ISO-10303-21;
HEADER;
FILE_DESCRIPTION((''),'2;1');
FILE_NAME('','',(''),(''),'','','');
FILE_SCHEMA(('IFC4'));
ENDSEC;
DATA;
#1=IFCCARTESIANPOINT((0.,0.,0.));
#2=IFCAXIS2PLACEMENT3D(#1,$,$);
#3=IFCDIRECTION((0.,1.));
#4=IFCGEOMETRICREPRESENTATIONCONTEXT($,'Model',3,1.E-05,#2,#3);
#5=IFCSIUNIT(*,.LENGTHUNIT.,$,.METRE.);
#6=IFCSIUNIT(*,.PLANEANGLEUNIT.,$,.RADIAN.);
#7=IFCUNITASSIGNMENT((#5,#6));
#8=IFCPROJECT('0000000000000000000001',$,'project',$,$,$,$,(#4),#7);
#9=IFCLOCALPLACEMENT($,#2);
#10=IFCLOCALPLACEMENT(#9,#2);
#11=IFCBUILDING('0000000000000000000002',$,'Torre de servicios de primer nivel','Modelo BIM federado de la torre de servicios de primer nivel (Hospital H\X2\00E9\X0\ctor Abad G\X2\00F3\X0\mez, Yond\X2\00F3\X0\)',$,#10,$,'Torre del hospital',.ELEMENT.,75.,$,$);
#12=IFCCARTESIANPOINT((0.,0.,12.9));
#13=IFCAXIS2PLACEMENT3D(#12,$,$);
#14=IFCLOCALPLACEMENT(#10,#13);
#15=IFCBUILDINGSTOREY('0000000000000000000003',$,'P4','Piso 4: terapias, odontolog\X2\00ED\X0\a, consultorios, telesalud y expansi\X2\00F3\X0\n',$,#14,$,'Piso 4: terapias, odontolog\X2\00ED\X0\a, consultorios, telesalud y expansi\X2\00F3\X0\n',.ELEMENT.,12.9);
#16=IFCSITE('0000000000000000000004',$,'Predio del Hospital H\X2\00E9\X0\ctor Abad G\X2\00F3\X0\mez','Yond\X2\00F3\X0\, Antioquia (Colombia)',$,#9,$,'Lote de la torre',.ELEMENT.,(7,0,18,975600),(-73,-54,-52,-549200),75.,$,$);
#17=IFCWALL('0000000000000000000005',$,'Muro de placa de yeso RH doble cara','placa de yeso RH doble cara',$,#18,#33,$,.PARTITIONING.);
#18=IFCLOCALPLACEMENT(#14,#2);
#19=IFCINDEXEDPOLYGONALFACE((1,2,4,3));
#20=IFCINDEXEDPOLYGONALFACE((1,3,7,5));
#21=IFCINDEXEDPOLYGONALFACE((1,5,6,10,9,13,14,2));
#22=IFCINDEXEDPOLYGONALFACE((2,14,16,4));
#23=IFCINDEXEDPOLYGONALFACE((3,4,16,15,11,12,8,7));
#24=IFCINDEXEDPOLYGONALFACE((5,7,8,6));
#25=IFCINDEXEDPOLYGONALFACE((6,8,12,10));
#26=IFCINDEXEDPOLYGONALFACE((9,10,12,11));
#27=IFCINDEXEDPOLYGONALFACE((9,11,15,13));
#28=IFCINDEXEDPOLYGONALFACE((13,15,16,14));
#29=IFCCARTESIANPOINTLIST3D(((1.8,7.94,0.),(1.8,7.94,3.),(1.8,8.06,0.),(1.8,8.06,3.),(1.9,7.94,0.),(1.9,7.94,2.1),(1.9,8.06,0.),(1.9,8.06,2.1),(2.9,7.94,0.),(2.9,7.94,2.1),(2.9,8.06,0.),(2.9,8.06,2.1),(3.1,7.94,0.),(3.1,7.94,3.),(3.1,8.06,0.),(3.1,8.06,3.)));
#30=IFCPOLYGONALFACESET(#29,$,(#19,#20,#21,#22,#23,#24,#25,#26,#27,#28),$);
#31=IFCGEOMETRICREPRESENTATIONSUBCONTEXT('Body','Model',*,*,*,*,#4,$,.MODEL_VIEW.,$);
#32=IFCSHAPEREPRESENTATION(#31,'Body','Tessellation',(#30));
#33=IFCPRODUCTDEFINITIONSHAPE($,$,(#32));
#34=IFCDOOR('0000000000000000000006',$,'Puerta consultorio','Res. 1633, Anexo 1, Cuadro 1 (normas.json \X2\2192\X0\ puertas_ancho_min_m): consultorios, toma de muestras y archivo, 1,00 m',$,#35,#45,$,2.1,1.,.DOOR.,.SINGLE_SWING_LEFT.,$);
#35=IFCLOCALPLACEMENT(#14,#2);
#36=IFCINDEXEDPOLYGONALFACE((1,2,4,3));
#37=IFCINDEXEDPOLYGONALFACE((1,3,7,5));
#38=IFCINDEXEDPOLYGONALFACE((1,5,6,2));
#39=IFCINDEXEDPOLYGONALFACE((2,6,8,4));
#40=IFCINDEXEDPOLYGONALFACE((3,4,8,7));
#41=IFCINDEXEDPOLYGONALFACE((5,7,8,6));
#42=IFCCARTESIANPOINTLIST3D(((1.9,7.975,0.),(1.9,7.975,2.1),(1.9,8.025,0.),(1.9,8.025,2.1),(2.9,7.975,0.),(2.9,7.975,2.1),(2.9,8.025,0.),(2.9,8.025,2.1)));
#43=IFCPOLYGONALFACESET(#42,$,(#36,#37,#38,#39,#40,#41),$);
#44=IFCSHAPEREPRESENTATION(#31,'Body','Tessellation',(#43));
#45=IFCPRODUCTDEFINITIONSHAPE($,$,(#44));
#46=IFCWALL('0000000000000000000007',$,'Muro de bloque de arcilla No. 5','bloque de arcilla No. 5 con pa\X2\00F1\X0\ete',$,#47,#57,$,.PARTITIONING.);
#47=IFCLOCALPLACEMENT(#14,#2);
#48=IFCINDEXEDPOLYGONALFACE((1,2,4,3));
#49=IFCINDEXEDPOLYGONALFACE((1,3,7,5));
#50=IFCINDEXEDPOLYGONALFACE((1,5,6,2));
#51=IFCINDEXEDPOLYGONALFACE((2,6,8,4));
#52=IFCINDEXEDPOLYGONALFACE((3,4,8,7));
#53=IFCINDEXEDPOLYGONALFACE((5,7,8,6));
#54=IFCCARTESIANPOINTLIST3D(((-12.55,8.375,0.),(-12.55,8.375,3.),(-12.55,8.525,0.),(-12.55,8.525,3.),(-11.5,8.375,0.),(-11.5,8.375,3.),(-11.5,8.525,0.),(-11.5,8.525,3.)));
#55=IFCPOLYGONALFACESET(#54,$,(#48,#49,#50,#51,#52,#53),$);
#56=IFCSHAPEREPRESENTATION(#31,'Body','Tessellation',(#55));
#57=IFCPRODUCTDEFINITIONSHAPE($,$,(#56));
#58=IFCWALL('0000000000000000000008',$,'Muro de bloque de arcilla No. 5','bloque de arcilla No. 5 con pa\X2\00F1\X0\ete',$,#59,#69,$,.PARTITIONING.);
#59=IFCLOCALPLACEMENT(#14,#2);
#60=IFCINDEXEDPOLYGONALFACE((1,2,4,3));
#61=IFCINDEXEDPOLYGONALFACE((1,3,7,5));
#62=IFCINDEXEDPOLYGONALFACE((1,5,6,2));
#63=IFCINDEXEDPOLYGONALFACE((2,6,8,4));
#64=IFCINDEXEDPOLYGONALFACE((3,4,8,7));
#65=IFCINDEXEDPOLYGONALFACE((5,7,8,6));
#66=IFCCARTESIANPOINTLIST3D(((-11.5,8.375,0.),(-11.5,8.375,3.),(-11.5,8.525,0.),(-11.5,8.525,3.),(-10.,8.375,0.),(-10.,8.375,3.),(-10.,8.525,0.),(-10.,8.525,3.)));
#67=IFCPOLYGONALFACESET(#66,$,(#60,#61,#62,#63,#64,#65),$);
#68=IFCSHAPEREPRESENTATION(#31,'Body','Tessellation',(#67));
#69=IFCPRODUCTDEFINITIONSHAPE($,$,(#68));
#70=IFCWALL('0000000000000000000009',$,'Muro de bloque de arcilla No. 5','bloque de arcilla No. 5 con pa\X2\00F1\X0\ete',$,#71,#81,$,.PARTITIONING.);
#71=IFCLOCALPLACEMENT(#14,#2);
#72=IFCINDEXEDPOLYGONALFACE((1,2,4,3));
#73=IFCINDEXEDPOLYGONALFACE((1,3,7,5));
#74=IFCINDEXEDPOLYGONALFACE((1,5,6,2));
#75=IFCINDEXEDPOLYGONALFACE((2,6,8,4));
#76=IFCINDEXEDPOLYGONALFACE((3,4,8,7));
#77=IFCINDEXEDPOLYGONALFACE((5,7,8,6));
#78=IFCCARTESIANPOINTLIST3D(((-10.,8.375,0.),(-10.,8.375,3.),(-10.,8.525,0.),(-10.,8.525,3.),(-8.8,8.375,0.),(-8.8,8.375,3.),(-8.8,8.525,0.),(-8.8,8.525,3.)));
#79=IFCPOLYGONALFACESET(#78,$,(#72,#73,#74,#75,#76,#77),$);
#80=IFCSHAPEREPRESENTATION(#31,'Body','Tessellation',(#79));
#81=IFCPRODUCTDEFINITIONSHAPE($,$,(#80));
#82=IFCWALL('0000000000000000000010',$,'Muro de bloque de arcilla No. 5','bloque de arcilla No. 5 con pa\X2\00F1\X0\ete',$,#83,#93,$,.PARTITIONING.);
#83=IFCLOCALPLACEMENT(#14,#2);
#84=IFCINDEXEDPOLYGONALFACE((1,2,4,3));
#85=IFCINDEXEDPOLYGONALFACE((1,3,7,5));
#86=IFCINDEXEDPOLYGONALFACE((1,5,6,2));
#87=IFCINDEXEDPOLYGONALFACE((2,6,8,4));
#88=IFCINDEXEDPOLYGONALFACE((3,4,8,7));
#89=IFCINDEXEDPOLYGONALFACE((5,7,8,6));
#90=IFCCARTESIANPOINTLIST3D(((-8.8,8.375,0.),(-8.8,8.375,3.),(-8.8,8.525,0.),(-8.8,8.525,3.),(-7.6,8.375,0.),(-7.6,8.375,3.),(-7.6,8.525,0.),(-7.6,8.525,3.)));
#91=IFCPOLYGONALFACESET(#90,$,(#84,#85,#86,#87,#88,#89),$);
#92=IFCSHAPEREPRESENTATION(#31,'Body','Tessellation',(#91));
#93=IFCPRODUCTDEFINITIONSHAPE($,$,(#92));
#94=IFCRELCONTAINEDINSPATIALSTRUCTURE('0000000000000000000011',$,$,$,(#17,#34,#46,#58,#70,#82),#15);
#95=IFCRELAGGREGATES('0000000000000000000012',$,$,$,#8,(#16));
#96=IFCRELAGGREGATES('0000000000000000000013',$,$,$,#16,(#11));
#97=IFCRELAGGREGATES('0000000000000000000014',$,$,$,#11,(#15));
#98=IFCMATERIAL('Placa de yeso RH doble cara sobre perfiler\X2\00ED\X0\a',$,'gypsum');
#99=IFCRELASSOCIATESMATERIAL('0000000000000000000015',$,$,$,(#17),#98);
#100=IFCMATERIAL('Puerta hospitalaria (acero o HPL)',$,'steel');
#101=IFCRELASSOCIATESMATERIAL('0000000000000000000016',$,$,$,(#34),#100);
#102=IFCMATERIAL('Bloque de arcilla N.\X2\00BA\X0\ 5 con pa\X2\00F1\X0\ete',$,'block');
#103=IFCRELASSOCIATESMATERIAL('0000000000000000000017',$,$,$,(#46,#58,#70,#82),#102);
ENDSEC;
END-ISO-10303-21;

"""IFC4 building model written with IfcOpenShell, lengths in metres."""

from ifc_helpers import new_model, si_unit, direction, frame, origin, place, context, subcontext, project, spatial, rectangle, extrude, material, element, fill, save


model = new_model("IFC4")

# Units and contexts
model_context = context("Model", 3, precision=1e-05, world=origin(), true_north=direction((0.0, 1.0)))
body_context = subcontext(model_context, "Body", "Model", "MODEL_VIEW")
ifc_project = project(units=[si_unit("LENGTHUNIT", "METRE"), si_unit("PLANEANGLEUNIT", "RADIAN")], contexts=[model_context])

# Site, building, storey
site_placement = place(None, origin())
site = spatial("IfcSite", under=ifc_project, at=site_placement, Name="Predio del Hospital Héctor Abad Gómez", Description="Yondó, Antioquia (Colombia)", LongName="Lote de la torre", CompositionType="ELEMENT", RefLatitude=(7, 0, 18, 975600), RefLongitude=(-73, -54, -52, -549200), RefElevation=75.0)
building_placement = place(site_placement, origin())
building = spatial("IfcBuilding", under=site, at=building_placement, Name="Torre de servicios de primer nivel", Description="Modelo BIM federado de la torre de servicios de primer nivel (Hospital Héctor Abad Gómez, Yondó)", LongName="Torre del hospital", CompositionType="ELEMENT", ElevationOfRefHeight=75.0)
placement = place(building_placement, frame((0.0, 0.0, 12.9)))
storey = spatial("IfcBuildingStorey", under=building, at=placement, Name="P4", Description="Piso 4: terapias, odontología, consultorios, telesalud y expansión", LongName="Piso 4: terapias, odontología, consultorios, telesalud y expansión", CompositionType="ELEMENT", Elevation=12.9)

# Shared definitions
ifc_material_1 = material(Name="Bloque de arcilla N.º 5 con pañete", Category="block")
ifc_material_2 = material(Name="Placa de yeso RH doble cara sobre perfilería", Category="gypsum")

# Shared definitions
ifc_material_3 = material(Name="Puerta hospitalaria (acero o HPL)", Category="steel")

# Wall, opening, door
wall_1 = element("IfcWall", 1, at=placement, inside=storey, material=ifc_material_2, Name="Muro de placa de yeso RH doble cara", Description="placa de yeso RH doble cara", PredefinedType="PARTITIONING", context=body_context, shape_type="SweptSolid", body=[
    extrude(rectangle(XDim=1.3, YDim=0.12), frame((2.45, 8.0, 0.0)), (0.0, 0.0, 1.0), 3.0),
])
opening_1 = element("IfcOpeningElement", 2, at=placement, cuts=wall_1, PredefinedType="OPENING", context=body_context, shape_type="SweptSolid", body=[
    extrude(rectangle(XDim=1.0, YDim=0.22), frame((2.4, 8.0, 0.0)), (0.0, 0.0, 1.0), 2.1),
])
door_1 = element("IfcDoor", 3, at=placement, inside=storey, material=ifc_material_3, Name="Puerta consultorio", Description="Res. 1633, Anexo 1, Cuadro 1 (normas.json → puertas_ancho_min_m): consultorios, toma de muestras y archivo, 1,00 m", OperationType="SINGLE_SWING_LEFT", OverallHeight=2.1, OverallWidth=1.0, PredefinedType="DOOR", context=body_context, shape_type="SweptSolid", body=[
    extrude(rectangle(XDim=1.0, YDim=0.05), frame((2.4, 8.0, 0.0)), (0.0, 0.0, 1.0), 2.1),
])
fill(opening_1, door_1)

# Walls
element("IfcWall", 4, at=placement, inside=storey, material=ifc_material_1, Name="Muro de bloque de arcilla No. 5", Description="bloque de arcilla No. 5 con pañete", PredefinedType="PARTITIONING", context=body_context, shape_type="SweptSolid", body=[
    extrude(rectangle(XDim=1.05, YDim=0.15), frame((-12.025, 8.45, 0.0)), (0.0, 0.0, 1.0), 3.0),
])
element("IfcWall", 5, at=placement, inside=storey, material=ifc_material_1, Name="Muro de bloque de arcilla No. 5", Description="bloque de arcilla No. 5 con pañete", PredefinedType="PARTITIONING", context=body_context, shape_type="SweptSolid", body=[
    extrude(rectangle(XDim=1.5, YDim=0.15), frame((-10.75, 8.45, 0.0)), (0.0, 0.0, 1.0), 3.0),
])
element("IfcWall", 6, at=placement, inside=storey, material=ifc_material_1, Name="Muro de bloque de arcilla No. 5", Description="bloque de arcilla No. 5 con pañete", PredefinedType="PARTITIONING", context=body_context, shape_type="SweptSolid", body=[
    extrude(rectangle(XDim=1.2, YDim=0.15), frame((-9.4, 8.45, 0.0)), (0.0, 0.0, 1.0), 3.0),
])
element("IfcWall", 7, at=placement, inside=storey, material=ifc_material_1, Name="Muro de bloque de arcilla No. 5", Description="bloque de arcilla No. 5 con pañete", PredefinedType="PARTITIONING", context=body_context, shape_type="SweptSolid", body=[
    extrude(rectangle(XDim=1.2, YDim=0.15), frame((-8.2, 8.45, 0.0)), (0.0, 0.0, 1.0), 3.0),
])

save(model, "model.ifc")
